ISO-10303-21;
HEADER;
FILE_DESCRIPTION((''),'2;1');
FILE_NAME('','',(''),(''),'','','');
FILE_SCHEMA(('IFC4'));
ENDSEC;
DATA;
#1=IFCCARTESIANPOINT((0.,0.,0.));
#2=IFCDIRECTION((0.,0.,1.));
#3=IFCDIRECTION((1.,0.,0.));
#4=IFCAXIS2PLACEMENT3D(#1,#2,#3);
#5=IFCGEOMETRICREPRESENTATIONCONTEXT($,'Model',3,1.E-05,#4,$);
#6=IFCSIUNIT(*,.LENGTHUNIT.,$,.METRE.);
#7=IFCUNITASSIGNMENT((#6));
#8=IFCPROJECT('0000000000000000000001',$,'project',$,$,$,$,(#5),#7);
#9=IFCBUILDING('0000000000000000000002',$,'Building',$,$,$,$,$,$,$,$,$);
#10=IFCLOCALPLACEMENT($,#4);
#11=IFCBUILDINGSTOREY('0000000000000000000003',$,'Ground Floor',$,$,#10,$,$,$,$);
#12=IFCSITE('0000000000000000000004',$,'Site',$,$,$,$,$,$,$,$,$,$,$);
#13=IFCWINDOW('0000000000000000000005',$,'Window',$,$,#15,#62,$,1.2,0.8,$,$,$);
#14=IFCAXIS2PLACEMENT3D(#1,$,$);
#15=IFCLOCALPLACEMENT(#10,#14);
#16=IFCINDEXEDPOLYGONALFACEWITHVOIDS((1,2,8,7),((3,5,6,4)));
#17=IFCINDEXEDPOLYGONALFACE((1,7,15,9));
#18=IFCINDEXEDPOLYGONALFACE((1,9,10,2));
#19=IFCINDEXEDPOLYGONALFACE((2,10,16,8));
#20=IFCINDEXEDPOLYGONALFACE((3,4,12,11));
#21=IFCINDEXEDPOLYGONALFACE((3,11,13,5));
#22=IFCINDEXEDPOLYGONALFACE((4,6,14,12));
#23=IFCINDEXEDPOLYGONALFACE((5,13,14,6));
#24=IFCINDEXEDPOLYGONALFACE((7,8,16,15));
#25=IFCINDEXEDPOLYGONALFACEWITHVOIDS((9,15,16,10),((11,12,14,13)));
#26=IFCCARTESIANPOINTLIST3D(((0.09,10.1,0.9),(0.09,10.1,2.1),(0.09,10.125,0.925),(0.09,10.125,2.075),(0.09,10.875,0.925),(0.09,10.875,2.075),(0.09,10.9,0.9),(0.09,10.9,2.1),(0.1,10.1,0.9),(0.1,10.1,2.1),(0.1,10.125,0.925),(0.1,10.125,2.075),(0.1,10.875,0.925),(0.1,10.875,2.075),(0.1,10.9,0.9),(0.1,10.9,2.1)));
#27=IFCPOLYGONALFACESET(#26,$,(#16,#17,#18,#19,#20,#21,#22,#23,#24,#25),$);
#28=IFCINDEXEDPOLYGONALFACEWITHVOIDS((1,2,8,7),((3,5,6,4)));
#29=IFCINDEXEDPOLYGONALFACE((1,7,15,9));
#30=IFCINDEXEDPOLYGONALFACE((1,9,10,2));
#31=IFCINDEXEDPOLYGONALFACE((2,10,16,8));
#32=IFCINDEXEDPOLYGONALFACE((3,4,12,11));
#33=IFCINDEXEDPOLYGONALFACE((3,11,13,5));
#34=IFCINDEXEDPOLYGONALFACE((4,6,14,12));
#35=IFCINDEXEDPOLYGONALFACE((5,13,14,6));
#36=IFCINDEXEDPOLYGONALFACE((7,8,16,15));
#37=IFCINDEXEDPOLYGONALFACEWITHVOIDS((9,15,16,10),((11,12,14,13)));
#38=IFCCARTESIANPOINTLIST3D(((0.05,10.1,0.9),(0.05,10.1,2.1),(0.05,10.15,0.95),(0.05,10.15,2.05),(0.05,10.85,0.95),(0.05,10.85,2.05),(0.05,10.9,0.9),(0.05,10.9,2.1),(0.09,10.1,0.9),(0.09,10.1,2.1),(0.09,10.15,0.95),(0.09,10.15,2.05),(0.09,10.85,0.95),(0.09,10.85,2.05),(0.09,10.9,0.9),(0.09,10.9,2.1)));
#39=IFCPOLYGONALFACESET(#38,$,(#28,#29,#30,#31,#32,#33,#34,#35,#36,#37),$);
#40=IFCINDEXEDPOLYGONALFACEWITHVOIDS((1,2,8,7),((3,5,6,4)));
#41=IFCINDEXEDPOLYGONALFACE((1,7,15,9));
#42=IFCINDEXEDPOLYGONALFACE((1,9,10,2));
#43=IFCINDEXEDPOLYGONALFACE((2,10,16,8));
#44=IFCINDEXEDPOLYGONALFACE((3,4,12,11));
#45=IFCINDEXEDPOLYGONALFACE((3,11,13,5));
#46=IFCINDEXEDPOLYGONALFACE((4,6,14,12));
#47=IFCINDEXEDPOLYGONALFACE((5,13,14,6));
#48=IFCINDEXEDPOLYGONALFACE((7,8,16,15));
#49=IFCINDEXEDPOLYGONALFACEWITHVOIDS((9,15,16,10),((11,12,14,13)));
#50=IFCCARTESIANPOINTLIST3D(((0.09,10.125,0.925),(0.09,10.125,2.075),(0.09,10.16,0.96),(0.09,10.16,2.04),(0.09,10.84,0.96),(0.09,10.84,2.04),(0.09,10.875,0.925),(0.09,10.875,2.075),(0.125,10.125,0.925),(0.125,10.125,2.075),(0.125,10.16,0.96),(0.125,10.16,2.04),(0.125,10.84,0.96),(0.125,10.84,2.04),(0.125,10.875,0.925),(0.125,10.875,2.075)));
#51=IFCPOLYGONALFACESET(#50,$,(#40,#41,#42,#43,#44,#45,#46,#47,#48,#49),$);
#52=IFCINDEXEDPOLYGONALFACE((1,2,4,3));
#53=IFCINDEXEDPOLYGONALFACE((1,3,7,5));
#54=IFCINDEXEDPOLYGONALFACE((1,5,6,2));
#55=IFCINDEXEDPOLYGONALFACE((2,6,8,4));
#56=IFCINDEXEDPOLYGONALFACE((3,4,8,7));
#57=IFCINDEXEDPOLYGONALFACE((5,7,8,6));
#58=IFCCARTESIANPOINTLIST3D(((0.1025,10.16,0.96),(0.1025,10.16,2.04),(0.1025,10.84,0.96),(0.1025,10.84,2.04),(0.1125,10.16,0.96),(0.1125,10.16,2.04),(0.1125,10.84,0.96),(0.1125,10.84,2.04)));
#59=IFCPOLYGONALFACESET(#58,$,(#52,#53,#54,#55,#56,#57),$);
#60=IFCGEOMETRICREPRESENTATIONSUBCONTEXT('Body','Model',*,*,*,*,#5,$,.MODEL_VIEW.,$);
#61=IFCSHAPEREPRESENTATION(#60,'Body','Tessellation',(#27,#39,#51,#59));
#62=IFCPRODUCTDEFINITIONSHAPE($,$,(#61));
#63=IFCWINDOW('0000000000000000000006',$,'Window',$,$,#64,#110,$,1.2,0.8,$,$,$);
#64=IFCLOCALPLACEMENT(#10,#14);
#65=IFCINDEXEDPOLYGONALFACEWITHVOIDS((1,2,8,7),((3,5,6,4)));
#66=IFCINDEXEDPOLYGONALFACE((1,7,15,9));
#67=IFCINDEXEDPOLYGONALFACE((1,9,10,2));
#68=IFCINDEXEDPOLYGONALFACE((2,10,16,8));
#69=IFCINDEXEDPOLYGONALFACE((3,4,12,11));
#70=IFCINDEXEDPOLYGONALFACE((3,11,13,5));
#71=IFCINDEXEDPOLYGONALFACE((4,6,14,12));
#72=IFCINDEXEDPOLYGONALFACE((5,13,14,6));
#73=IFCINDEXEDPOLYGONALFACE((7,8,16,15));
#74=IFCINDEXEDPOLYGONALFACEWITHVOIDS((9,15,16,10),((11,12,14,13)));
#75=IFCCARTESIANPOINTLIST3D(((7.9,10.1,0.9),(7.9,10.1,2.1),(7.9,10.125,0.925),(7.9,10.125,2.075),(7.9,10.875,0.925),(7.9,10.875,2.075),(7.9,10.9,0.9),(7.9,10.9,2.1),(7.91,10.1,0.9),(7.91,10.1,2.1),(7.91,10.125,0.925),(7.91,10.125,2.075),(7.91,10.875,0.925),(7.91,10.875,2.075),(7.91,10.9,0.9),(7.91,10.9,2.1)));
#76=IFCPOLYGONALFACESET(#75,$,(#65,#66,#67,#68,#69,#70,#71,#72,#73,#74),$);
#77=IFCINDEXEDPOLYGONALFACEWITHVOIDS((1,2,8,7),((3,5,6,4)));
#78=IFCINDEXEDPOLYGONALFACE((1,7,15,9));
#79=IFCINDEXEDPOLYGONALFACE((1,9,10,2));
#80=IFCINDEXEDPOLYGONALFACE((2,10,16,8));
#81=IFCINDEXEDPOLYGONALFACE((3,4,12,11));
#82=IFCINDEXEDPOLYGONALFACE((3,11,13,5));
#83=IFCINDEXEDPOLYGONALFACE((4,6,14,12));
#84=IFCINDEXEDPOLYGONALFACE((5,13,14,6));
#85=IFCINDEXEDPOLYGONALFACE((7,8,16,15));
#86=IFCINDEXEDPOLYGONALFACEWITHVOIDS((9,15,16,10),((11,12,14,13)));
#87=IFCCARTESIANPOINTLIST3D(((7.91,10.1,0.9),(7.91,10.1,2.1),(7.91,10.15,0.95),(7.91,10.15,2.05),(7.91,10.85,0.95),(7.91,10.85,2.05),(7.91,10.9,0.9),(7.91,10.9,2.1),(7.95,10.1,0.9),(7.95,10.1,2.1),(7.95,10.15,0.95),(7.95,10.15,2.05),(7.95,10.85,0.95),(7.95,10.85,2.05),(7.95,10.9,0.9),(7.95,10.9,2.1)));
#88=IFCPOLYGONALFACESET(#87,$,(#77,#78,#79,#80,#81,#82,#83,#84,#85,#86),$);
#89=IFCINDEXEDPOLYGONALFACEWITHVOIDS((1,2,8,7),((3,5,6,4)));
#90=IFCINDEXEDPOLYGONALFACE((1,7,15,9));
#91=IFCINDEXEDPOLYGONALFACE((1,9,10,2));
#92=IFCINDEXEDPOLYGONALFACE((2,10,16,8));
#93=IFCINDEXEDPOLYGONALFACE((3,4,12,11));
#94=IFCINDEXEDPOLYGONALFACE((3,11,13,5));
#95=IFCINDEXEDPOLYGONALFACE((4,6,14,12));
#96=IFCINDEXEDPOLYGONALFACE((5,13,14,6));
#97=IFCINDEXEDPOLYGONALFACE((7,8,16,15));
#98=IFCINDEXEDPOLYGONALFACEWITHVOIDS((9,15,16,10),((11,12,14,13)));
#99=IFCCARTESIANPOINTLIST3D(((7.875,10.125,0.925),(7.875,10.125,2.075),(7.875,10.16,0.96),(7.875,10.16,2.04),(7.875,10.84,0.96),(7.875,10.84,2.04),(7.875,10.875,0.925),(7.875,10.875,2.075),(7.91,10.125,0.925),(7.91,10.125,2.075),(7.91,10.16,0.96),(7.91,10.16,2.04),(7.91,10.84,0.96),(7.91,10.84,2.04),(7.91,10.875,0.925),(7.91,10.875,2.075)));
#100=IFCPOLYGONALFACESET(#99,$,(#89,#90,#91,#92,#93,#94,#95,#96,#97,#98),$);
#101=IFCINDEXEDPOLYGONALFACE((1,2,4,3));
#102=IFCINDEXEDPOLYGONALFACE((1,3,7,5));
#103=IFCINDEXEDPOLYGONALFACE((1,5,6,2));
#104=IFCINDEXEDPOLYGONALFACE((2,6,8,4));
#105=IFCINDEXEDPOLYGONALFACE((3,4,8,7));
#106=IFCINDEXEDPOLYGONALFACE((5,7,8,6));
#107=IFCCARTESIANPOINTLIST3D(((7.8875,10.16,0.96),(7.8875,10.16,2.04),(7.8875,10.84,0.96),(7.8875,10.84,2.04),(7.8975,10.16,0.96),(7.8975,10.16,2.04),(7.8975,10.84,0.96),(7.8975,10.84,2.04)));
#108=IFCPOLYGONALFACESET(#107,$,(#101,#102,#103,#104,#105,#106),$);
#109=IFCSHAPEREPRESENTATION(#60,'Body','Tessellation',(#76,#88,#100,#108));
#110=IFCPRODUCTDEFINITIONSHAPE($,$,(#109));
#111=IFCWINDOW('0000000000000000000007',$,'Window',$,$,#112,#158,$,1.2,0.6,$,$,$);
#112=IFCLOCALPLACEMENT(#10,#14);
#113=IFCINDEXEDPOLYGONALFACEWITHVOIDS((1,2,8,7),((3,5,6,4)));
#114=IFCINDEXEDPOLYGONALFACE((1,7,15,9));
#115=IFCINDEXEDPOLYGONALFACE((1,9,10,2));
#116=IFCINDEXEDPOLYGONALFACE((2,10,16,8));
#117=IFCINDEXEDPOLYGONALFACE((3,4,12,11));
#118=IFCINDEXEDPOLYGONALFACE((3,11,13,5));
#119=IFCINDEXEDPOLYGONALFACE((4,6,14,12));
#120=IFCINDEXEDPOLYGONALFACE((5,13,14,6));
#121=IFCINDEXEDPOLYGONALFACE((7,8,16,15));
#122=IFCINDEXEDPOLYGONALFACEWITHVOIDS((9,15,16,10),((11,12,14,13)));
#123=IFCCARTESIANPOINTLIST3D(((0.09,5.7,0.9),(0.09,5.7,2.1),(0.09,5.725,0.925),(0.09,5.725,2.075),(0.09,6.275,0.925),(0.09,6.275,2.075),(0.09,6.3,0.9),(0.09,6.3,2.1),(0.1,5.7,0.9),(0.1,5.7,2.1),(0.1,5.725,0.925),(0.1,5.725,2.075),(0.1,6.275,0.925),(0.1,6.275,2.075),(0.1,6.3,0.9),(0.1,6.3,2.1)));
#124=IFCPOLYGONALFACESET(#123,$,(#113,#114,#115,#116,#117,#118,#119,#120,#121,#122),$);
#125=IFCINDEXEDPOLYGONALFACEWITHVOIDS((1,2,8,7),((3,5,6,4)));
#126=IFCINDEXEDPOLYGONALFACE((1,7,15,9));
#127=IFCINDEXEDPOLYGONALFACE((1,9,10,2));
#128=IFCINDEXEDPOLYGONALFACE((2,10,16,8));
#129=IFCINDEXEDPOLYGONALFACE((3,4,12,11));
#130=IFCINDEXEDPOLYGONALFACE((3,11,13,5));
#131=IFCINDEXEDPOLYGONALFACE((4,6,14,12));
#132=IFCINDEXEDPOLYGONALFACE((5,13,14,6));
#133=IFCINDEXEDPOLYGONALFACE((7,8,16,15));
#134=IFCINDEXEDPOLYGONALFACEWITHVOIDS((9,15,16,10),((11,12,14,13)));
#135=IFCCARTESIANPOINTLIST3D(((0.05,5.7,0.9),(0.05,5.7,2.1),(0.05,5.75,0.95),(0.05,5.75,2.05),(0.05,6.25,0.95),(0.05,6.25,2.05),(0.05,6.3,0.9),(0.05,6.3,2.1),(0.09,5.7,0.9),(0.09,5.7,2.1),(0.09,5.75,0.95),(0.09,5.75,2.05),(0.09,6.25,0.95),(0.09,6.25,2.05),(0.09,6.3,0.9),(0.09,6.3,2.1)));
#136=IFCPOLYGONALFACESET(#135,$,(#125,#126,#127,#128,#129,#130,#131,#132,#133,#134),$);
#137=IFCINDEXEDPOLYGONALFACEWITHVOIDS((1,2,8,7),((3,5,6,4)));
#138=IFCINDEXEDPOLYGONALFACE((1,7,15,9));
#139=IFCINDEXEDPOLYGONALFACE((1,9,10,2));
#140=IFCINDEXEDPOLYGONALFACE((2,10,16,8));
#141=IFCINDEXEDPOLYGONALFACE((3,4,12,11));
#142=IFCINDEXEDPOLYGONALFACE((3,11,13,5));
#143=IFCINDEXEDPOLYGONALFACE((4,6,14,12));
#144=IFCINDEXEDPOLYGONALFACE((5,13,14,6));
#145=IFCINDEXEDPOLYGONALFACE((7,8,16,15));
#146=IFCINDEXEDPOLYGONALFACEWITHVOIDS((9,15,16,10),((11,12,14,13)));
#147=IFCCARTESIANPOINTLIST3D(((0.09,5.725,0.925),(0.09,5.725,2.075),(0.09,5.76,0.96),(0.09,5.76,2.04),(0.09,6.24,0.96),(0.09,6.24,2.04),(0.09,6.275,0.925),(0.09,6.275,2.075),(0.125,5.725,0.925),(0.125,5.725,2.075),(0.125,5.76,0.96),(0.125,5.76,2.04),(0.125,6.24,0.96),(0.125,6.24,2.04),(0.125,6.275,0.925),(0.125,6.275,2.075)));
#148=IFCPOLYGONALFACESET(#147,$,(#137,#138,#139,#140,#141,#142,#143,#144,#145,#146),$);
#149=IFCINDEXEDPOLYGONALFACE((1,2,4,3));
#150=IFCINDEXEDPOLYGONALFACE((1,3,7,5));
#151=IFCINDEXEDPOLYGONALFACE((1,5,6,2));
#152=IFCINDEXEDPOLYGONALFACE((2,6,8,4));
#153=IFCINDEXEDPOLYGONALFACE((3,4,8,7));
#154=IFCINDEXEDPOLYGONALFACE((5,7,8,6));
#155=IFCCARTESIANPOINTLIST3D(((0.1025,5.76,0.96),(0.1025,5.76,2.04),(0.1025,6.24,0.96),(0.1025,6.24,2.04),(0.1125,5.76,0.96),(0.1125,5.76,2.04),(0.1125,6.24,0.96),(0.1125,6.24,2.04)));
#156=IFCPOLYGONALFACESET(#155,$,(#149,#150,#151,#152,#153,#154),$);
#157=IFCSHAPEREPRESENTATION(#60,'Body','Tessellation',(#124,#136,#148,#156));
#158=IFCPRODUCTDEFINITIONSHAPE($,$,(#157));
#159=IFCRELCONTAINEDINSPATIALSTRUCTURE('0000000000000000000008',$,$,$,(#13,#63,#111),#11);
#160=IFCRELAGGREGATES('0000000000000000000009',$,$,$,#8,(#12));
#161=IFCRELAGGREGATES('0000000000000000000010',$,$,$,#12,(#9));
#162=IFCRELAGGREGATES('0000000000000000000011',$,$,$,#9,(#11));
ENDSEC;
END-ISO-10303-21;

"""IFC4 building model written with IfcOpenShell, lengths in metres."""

from ifc_helpers import new_model, si_unit, frame, origin_with_axes, place, context, subcontext, project, spatial, line, indexed_curve, outline, extrude, element, save


model = new_model("IFC4")

# Units and contexts
model_context = context("Model", 3, precision=1e-05, world=origin_with_axes())
body_context = subcontext(model_context, "Body", "Model", "MODEL_VIEW")
ifc_project = project(units=[si_unit("LENGTHUNIT", "METRE")], contexts=[model_context])

# Site, building, storey
site = spatial("IfcSite", under=ifc_project, Name="Site")
building = spatial("IfcBuilding", under=site, Name="Building")
storey_placement = place(None, origin_with_axes())
storey = spatial("IfcBuildingStorey", under=building, at=storey_placement, Name="Ground Floor")

# Windows
for number, where, z_axis, x_axis, name in (
    (1, (0.0, 10.9, 0.9), (0.0, 0.0, 1.0), (0.0, -1.0, 0.0), "Window"),
    (2, (8.0, 10.1, 0.9), (0.0, 0.0, 1.0), (0.0, 1.0, 0.0), "Window"),
):
    element("IfcWindow", number, at=place(storey_placement, frame(where, z_axis=z_axis, x_axis=x_axis)), inside=storey, Name=name, OverallHeight=1.2, OverallWidth=0.8, context=body_context, shape_type="SweptSolid", body=[
        extrude(outline(indexed_curve([(0.0, 0.0), (0.8, 0.0), (0.8, 1.2), (0.0, 1.2)], segments=[line(1, 2, 3, 4, 1)]), holes=[indexed_curve([(0.025, 0.025), (0.775, 0.025), (0.775, 1.175), (0.025, 1.175)], segments=[line(1, 2, 3, 4, 1)])]), frame((0.0, 0.09, 0.0), z_axis=(0.0, -1.0, 0.0), x_axis=(1.0, 0.0, 0.0)), (0.0, 0.0, -1.0), 0.01),
        extrude(outline(indexed_curve([(0.0, 0.0), (0.8, 0.0), (0.8, 1.2), (0.0, 1.2)], segments=[line(1, 2, 3, 4, 1)]), holes=[indexed_curve([(0.05, 0.05), (0.75, 0.05), (0.75, 1.15), (0.05, 1.15)], segments=[line(1, 2, 3, 4, 1)])]), frame((0.0, 0.05, 0.0), z_axis=(0.0, -1.0, 0.0), x_axis=(1.0, 0.0, 0.0)), (0.0, 0.0, -1.0), 0.04),
        extrude(outline(indexed_curve([(0.0, 0.0), (0.75, 0.0), (0.75, 1.15), (0.0, 1.15)], segments=[line(1, 2, 3, 4, 1)]), holes=[indexed_curve([(0.035, 0.035), (0.715, 0.035), (0.715, 1.115), (0.035, 1.115)], segments=[line(1, 2, 3, 4, 1)])]), frame((0.025, 0.09, 0.025), z_axis=(0.0, -1.0, 0.0), x_axis=(1.0, 0.0, 0.0)), (0.0, 0.0, -1.0), 0.035),
        extrude(outline(indexed_curve([(0.035, 0.035), (0.715, 0.035), (0.715, 1.115), (0.035, 1.115)], segments=[line(1, 2, 3, 4, 1)])), frame((0.025, 0.1025, 0.025), z_axis=(0.0, -1.0, 0.0), x_axis=(1.0, 0.0, 0.0)), (0.0, 0.0, -1.0), 0.01),
    ])
window_1_placement = place(storey_placement, frame((0.0, 6.3, 0.9), z_axis=(0.0, 0.0, 1.0), x_axis=(0.0, -1.0, 0.0)))
element("IfcWindow", 3, at=window_1_placement, inside=storey, Name="Window", OverallHeight=1.2, OverallWidth=0.6, context=body_context, shape_type="SweptSolid", body=[
    extrude(outline(indexed_curve([(0.0, 0.0), (0.6, 0.0), (0.6, 1.2), (0.0, 1.2)], segments=[line(1, 2, 3, 4, 1)]), holes=[indexed_curve([(0.025, 0.025), (0.575, 0.025), (0.575, 1.175), (0.025, 1.175)], segments=[line(1, 2, 3, 4, 1)])]), frame((0.0, 0.09, 0.0), z_axis=(0.0, -1.0, 0.0), x_axis=(1.0, 0.0, 0.0)), (0.0, 0.0, -1.0), 0.01),
    extrude(outline(indexed_curve([(0.0, 0.0), (0.6, 0.0), (0.6, 1.2), (0.0, 1.2)], segments=[line(1, 2, 3, 4, 1)]), holes=[indexed_curve([(0.05, 0.05), (0.55, 0.05), (0.55, 1.15), (0.05, 1.15)], segments=[line(1, 2, 3, 4, 1)])]), frame((0.0, 0.05, 0.0), z_axis=(0.0, -1.0, 0.0), x_axis=(1.0, 0.0, 0.0)), (0.0, 0.0, -1.0), 0.04),
    extrude(outline(indexed_curve([(0.0, 0.0), (0.55, 0.0), (0.55, 1.15), (0.0, 1.15)], segments=[line(1, 2, 3, 4, 1)]), holes=[indexed_curve([(0.035, 0.035), (0.515, 0.035), (0.515, 1.115), (0.035, 1.115)], segments=[line(1, 2, 3, 4, 1)])]), frame((0.025, 0.09, 0.025), z_axis=(0.0, -1.0, 0.0), x_axis=(1.0, 0.0, 0.0)), (0.0, 0.0, -1.0), 0.035),
    extrude(outline(indexed_curve([(0.035, 0.035), (0.515, 0.035), (0.515, 1.115), (0.035, 1.115)], segments=[line(1, 2, 3, 4, 1)])), frame((0.025, 0.1025, 0.025), z_axis=(0.0, -1.0, 0.0), x_axis=(1.0, 0.0, 0.0)), (0.0, 0.0, -1.0), 0.01),
])

save(model, "model.ifc")
